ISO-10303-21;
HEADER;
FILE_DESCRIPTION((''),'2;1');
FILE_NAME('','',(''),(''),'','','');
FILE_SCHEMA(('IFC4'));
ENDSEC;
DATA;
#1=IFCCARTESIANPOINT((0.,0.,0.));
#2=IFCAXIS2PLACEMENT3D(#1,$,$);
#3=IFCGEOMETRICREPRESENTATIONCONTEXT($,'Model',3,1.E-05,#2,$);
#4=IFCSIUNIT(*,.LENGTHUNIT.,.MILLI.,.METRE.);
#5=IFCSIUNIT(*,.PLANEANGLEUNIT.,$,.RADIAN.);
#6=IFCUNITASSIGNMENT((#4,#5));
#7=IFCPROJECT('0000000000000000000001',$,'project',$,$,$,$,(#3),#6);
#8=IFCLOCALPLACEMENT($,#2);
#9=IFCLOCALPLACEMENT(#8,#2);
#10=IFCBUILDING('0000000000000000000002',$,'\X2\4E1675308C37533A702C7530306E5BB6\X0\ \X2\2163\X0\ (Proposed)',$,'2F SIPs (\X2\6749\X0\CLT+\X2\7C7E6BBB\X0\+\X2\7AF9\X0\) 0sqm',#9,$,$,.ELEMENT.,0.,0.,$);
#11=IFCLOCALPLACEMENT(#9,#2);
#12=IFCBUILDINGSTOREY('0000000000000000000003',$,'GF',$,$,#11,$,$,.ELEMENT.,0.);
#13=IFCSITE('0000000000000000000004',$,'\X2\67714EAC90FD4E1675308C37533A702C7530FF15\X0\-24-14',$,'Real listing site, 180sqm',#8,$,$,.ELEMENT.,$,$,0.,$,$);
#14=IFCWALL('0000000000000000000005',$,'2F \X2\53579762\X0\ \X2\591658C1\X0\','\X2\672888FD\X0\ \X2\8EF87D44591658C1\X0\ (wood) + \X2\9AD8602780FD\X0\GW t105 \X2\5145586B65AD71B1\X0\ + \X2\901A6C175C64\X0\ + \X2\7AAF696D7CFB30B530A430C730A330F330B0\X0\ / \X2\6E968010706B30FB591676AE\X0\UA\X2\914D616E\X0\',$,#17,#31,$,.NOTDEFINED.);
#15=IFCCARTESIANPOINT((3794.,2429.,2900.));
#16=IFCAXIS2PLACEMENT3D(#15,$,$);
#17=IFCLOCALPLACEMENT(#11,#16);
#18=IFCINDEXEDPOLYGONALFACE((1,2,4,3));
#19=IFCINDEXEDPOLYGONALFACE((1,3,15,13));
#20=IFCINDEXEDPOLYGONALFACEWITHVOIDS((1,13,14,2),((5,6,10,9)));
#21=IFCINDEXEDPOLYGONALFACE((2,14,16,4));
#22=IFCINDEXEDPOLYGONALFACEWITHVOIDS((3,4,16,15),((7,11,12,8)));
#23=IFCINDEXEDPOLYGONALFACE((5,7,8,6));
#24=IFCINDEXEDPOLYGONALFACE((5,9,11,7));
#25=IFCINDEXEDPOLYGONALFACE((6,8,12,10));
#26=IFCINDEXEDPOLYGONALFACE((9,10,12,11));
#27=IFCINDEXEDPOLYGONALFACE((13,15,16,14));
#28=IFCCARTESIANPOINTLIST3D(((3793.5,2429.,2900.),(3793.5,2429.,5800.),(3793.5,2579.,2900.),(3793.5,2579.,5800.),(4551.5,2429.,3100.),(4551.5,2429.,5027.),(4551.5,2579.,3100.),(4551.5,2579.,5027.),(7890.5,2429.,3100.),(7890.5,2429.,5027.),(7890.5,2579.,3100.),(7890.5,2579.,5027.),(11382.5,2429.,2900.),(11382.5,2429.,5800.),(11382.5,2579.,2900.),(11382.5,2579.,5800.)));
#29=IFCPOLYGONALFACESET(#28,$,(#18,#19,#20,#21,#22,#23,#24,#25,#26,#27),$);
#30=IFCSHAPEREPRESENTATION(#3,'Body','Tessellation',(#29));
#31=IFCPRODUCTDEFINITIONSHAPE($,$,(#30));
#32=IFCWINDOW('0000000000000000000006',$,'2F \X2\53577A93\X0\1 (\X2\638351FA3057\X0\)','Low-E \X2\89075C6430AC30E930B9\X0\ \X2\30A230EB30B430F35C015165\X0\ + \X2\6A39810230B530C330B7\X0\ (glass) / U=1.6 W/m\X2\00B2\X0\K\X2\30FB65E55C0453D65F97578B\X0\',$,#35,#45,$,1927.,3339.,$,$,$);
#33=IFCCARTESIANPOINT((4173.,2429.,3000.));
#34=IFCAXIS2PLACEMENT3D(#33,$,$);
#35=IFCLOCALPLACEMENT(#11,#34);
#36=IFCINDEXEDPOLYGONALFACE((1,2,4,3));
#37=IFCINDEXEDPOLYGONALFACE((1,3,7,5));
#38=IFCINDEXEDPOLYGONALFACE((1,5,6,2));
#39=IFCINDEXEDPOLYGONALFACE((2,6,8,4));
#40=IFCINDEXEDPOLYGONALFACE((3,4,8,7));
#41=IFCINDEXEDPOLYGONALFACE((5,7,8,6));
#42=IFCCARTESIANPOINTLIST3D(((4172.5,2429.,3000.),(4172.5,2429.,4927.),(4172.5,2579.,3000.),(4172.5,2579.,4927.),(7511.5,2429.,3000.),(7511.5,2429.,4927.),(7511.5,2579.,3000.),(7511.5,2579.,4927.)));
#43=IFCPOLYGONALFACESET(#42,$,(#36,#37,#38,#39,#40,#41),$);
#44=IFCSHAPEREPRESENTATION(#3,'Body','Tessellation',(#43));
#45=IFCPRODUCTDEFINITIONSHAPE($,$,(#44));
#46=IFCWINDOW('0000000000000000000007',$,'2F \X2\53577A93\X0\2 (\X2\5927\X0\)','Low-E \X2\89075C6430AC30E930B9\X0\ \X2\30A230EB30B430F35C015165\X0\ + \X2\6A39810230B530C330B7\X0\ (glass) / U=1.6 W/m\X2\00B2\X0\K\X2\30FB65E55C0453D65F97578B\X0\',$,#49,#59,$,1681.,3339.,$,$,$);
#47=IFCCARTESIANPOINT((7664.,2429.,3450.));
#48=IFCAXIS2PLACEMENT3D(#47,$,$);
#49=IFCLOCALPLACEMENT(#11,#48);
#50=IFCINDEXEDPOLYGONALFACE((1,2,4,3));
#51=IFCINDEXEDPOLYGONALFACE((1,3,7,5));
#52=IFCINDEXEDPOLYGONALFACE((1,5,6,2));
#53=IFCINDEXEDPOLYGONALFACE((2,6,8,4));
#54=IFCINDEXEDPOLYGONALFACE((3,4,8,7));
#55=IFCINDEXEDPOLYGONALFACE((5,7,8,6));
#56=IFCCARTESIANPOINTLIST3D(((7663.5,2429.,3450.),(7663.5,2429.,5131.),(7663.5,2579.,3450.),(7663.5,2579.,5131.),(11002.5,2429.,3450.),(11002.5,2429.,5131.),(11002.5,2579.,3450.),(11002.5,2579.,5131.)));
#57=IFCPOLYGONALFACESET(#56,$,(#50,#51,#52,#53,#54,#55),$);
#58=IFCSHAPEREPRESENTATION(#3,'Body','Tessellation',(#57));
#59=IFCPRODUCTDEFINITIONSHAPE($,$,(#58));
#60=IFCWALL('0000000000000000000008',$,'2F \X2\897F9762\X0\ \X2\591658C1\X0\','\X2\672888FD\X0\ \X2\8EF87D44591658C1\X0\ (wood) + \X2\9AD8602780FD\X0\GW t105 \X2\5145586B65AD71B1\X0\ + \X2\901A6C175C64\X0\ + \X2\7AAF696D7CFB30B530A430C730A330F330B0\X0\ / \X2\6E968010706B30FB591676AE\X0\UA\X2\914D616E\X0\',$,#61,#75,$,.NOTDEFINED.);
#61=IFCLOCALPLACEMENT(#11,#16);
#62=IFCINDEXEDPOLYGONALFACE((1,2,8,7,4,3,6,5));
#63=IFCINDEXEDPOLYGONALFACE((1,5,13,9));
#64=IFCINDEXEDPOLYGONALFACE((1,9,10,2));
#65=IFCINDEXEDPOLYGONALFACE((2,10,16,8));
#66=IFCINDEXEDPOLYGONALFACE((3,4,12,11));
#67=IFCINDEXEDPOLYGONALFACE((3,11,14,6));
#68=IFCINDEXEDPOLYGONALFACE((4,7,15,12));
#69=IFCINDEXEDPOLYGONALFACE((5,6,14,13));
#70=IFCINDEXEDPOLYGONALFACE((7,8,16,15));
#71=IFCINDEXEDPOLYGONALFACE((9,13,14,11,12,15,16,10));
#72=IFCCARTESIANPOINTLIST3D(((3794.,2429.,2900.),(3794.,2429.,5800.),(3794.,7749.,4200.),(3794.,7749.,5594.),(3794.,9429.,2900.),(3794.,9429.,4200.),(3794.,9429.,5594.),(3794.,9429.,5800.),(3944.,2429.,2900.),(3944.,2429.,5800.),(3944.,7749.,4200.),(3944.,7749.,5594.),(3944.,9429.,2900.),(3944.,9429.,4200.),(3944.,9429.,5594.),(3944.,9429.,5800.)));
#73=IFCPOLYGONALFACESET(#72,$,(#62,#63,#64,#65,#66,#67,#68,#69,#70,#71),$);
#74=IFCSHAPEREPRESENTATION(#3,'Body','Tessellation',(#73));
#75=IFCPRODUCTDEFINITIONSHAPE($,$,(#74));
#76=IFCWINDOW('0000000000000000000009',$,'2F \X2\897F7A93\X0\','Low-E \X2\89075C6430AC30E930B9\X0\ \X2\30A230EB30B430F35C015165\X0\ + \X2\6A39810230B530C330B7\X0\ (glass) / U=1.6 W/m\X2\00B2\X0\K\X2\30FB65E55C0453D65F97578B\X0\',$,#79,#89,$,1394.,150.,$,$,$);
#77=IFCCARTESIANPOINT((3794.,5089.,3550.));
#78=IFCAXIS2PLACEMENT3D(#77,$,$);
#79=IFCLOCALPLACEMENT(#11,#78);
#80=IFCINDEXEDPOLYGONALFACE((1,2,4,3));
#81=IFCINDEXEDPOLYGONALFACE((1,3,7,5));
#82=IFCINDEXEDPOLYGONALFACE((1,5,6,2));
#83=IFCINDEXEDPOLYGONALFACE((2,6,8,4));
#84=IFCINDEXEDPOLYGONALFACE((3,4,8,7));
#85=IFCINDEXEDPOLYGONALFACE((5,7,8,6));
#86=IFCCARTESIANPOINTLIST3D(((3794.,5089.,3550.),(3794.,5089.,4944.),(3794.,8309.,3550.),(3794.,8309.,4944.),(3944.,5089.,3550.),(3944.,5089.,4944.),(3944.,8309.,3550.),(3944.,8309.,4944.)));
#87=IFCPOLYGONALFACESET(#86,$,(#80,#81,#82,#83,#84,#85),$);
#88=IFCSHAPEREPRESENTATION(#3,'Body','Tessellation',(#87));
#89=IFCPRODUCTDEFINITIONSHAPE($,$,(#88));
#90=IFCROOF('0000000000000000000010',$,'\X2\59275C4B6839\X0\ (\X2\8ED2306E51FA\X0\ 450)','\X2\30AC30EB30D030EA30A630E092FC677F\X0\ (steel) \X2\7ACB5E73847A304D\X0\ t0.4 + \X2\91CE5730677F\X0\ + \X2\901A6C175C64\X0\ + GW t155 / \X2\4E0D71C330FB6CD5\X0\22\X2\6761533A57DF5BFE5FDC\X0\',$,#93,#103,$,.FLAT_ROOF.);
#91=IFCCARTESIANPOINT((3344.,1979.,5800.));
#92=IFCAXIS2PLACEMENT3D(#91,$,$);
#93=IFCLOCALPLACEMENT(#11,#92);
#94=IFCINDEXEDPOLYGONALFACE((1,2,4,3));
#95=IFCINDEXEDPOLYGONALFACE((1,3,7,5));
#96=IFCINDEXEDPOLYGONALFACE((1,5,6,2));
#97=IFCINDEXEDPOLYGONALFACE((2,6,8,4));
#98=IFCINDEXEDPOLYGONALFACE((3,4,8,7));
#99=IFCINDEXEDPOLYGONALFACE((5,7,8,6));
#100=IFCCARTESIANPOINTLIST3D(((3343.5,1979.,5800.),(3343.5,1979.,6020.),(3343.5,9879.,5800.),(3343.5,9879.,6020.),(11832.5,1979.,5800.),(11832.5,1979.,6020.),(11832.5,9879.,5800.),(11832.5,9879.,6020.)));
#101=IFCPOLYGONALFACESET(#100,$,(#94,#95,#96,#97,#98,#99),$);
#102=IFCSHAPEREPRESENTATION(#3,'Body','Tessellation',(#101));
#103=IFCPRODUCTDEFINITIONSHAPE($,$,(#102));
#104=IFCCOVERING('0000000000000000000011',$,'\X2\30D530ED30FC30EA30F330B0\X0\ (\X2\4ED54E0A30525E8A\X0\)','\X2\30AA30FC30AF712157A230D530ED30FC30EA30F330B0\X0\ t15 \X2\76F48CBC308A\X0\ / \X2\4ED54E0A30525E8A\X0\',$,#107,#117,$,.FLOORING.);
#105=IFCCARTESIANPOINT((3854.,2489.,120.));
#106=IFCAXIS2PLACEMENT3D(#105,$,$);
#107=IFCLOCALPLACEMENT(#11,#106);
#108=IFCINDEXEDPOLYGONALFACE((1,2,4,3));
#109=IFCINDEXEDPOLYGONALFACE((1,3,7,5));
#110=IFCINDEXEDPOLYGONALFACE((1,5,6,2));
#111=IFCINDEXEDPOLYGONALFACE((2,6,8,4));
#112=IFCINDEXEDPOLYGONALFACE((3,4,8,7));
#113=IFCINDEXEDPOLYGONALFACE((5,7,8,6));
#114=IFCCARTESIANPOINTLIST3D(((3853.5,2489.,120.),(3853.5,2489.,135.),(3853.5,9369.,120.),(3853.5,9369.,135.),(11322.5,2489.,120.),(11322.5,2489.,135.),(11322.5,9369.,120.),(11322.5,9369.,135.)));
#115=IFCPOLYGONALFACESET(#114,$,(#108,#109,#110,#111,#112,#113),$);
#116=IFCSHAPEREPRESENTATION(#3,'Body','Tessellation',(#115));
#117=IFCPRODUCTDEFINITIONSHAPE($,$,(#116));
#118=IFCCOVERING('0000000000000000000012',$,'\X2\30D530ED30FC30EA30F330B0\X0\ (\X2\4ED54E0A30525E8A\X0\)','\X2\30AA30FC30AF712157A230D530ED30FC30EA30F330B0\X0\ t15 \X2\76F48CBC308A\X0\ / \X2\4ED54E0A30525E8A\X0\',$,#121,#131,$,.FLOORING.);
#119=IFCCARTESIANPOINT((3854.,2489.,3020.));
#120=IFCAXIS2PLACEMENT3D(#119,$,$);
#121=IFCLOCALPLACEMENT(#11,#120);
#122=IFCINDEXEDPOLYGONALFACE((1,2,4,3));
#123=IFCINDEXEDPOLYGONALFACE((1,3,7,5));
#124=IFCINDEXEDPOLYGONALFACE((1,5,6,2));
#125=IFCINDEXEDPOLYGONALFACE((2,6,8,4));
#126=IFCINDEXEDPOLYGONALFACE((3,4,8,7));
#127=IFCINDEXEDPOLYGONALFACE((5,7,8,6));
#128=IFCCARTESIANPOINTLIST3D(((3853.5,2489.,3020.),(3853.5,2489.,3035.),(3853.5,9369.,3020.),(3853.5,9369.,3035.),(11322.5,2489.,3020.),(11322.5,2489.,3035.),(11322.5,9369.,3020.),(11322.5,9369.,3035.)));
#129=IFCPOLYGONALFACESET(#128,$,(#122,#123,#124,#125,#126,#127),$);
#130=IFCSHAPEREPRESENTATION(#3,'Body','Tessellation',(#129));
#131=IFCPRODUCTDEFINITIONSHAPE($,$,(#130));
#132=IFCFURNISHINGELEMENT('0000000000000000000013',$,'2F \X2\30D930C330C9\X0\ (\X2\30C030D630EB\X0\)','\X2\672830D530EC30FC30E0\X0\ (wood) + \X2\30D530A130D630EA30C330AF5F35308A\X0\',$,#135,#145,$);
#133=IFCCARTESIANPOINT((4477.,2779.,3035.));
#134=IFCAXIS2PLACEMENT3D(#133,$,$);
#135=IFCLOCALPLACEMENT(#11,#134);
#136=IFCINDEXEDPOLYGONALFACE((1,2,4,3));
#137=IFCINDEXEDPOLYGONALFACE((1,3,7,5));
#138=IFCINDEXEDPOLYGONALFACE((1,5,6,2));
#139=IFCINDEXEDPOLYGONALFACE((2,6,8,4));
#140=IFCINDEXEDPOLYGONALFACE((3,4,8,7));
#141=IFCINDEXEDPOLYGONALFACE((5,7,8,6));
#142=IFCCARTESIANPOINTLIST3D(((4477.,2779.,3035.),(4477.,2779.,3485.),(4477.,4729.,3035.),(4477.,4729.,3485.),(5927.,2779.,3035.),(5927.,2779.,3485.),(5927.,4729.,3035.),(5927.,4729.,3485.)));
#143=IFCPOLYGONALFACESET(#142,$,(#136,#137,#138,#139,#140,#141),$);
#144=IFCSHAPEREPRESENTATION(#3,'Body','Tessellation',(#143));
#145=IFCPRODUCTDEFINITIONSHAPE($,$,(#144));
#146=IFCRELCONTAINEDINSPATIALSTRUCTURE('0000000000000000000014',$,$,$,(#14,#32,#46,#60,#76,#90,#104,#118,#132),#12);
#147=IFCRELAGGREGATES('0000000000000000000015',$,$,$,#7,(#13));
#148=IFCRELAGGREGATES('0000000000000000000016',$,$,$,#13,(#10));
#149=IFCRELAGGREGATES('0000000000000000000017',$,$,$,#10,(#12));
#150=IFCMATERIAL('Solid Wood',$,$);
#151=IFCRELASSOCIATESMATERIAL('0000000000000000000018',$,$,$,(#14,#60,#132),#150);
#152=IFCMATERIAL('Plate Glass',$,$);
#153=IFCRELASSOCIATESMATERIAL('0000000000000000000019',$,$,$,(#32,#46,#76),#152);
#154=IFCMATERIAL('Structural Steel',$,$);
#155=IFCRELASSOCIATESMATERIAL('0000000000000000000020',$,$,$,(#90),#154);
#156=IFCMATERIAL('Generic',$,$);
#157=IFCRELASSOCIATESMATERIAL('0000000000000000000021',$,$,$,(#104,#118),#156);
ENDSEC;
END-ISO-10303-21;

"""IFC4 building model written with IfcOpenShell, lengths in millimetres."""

from ifc_helpers import new_model, si_unit, frame, frame_2d, origin, place, context, project, spatial, rectangle, extrude, material, element, fill, save


model = new_model("IFC4")

# Units and contexts
model_context = context("Model", 3, precision=1e-05, world=origin())
ifc_project = project(units=[si_unit("LENGTHUNIT", "METRE", prefix="MILLI"), si_unit("PLANEANGLEUNIT", "RADIAN")], contexts=[model_context])

# Site, building, storey
site_placement = place(None, origin())
site = spatial("IfcSite", under=ifc_project, at=site_placement, Name="東京都世田谷区瀬田５-24-14", ObjectType="Real listing site, 180sqm", CompositionType="ELEMENT", RefElevation=0.0)
building_placement = place(site_placement, origin())
building = spatial("IfcBuilding", under=site, at=building_placement, Name="世田谷区瀬田の家 Ⅳ (Proposed)", ObjectType="2F SIPs (杉CLT+籾殻+竹) 0sqm", CompositionType="ELEMENT", ElevationOfRefHeight=0.0, ElevationOfTerrain=0.0)
storey_placement = place(building_placement, origin())
storey = spatial("IfcBuildingStorey", under=building, at=storey_placement, Name="GF", CompositionType="ELEMENT", Elevation=0.0)

# Shared definitions
ifc_material_1 = material(Name="Solid Wood")

# Shared definitions
ifc_material_2 = material(Name="Plate Glass")

# Wall, openings, windows
wall_1_placement = place(storey_placement, frame((3794.0, 2429.0, 2900.0)))
wall_1 = element("IfcWall", 1, at=wall_1_placement, inside=storey, material=ifc_material_1, Name="2F 南面 外壁", Description="木製 軸組外壁 (wood) + 高性能GW t105 充填断熱 + 通気層 + 窯業系サイディング / 準耐火・外皮UA配慮", PredefinedType="NOTDEFINED", context=model_context, shape_type="SweptSolid", body=[
    extrude(rectangle(XDim=7589.0, YDim=150.0, at=frame_2d((3794.0, 75.0))), frame((3794.0, 2429.0, 2900.0)), (0.0, 0.0, 1.0), 2900.0),
])
opening_1_placement = place(storey_placement, frame((4173.0, 2429.0, 3000.0)))
opening_1 = element("IfcOpeningElement", 2, at=opening_1_placement, cuts=wall_1, PredefinedType="NOTDEFINED", context=model_context, shape_type="SweptSolid", body=[
    extrude(rectangle(XDim=3339.0, YDim=150.0, at=frame_2d((1669.0, 75.0))), frame((4173.0, 2429.0, 3000.0)), (0.0, 0.0, 1.0), 1927.0),
])
opening_2_placement = place(storey_placement, frame((7664.0, 2429.0, 3450.0)))
opening_2 = element("IfcOpeningElement", 3, at=opening_2_placement, cuts=wall_1, PredefinedType="NOTDEFINED", context=model_context, shape_type="SweptSolid", body=[
    extrude(rectangle(XDim=3339.0, YDim=150.0, at=frame_2d((1669.0, 75.0))), frame((7664.0, 2429.0, 3450.0)), (0.0, 0.0, 1.0), 1681.0),
])
window_1_placement = place(storey_placement, frame((4173.0, 2429.0, 3000.0)))
window_1 = element("IfcWindow", 4, at=window_1_placement, inside=storey, material=ifc_material_2, Name="2F 南窓1 (掃出し)", Description="Low-E 複層ガラス アルゴン封入 + 樹脂サッシ (glass) / U=1.6 W/m²K・日射取得型", OverallHeight=1927.0, OverallWidth=3339.0, context=model_context, shape_type="SweptSolid", body=[
    extrude(rectangle(XDim=3339.0, YDim=150.0, at=frame_2d((1669.0, 75.0))), frame((4173.0, 2429.0, 3000.0)), (0.0, 0.0, 1.0), 1927.0),
])
fill(opening_1, window_1)
window_2_placement = place(storey_placement, frame((7664.0, 2429.0, 3450.0)))
window_2 = element("IfcWindow", 5, at=window_2_placement, inside=storey, material=ifc_material_2, Name="2F 南窓2 (大)", Description="Low-E 複層ガラス アルゴン封入 + 樹脂サッシ (glass) / U=1.6 W/m²K・日射取得型", OverallHeight=1681.0, OverallWidth=3339.0, context=model_context, shape_type="SweptSolid", body=[
    extrude(rectangle(XDim=3339.0, YDim=150.0, at=frame_2d((1669.0, 75.0))), frame((7664.0, 2429.0, 3450.0)), (0.0, 0.0, 1.0), 1681.0),
])
fill(opening_2, window_2)

# Wall, opening, window
wall_2_placement = place(storey_placement, frame((3794.0, 2429.0, 2900.0)))
wall_2 = element("IfcWall", 6, at=wall_2_placement, inside=storey, material=ifc_material_1, Name="2F 西面 外壁", Description="木製 軸組外壁 (wood) + 高性能GW t105 充填断熱 + 通気層 + 窯業系サイディング / 準耐火・外皮UA配慮", PredefinedType="NOTDEFINED", context=model_context, shape_type="SweptSolid", body=[
    extrude(rectangle(XDim=150.0, YDim=7000.0, at=frame_2d((75.0, 3500.0))), frame((3794.0, 2429.0, 2900.0)), (0.0, 0.0, 1.0), 2900.0),
])
opening_3_placement = place(storey_placement, frame((3794.0, 5089.0, 3550.0)))
opening_3 = element("IfcOpeningElement", 7, at=opening_3_placement, cuts=wall_2, PredefinedType="NOTDEFINED", context=model_context, shape_type="SweptSolid", body=[
    extrude(rectangle(XDim=150.0, YDim=3220.0, at=frame_2d((75.0, 1610.0))), frame((3794.0, 5089.0, 3550.0)), (0.0, 0.0, 1.0), 1394.0),
])
window_3_placement = place(storey_placement, frame((3794.0, 5089.0, 3550.0)))
window_3 = element("IfcWindow", 8, at=window_3_placement, inside=storey, material=ifc_material_2, Name="2F 西窓", Description="Low-E 複層ガラス アルゴン封入 + 樹脂サッシ (glass) / U=1.6 W/m²K・日射取得型", OverallHeight=1394.0, OverallWidth=150.0, context=model_context, shape_type="SweptSolid", body=[
    extrude(rectangle(XDim=150.0, YDim=3220.0, at=frame_2d((75.0, 1610.0))), frame((3794.0, 5089.0, 3550.0)), (0.0, 0.0, 1.0), 1394.0),
])
fill(opening_3, window_3)

# Roof
ifc_material_3 = material(Name="Structural Steel")
roof_placement = place(storey_placement, frame((3344.0, 1979.0, 5800.0)))
element("IfcRoof", 9, at=roof_placement, inside=storey, material=ifc_material_3, Name="大屋根 (軒の出 450)", Description="ガルバリウム鋼板 (steel) 立平葺き t0.4 + 野地板 + 通気層 + GW t155 / 不燃・法22条区域対応", PredefinedType="FLAT_ROOF", context=model_context, shape_type="SweptSolid", body=[
    extrude(rectangle(XDim=8489.0, YDim=7900.0, at=frame_2d((4244.0, 3950.0))), frame((3344.0, 1979.0, 5800.0)), (0.0, 0.0, 1.0), 220.0),
])

# Coverings
ifc_material_4 = material(Name="Generic")
covering_1_placement = place(storey_placement, frame((3854.0, 2489.0, 120.0)))
element("IfcCovering", 10, at=covering_1_placement, inside=storey, material=ifc_material_4, Name="フローリング (仕上げ床)", Description="オーク無垢フローリング t15 直貼り / 仕上げ床", PredefinedType="FLOORING", context=model_context, shape_type="SweptSolid", body=[
    extrude(rectangle(XDim=7469.0, YDim=6880.0, at=frame_2d((3734.0, 3440.0))), frame((3854.0, 2489.0, 120.0)), (0.0, 0.0, 1.0), 15.0),
])
covering_2_placement = place(storey_placement, frame((3854.0, 2489.0, 3020.0)))
element("IfcCovering", 11, at=covering_2_placement, inside=storey, material=ifc_material_4, Name="フローリング (仕上げ床)", Description="オーク無垢フローリング t15 直貼り / 仕上げ床", PredefinedType="FLOORING", context=model_context, shape_type="SweptSolid", body=[
    extrude(rectangle(XDim=7469.0, YDim=6880.0, at=frame_2d((3734.0, 3440.0))), frame((3854.0, 2489.0, 3020.0)), (0.0, 0.0, 1.0), 15.0),
])

# Furnishing element
furnishing_placement = place(storey_placement, frame((4477.0, 2779.0, 3035.0)))
element("IfcFurnishingElement", 12, at=furnishing_placement, inside=storey, material=ifc_material_1, Name="2F ベッド (ダブル)", Description="木フレーム (wood) + ファブリック張り", context=model_context, shape_type="SweptSolid", body=[
    extrude(rectangle(XDim=1450.0, YDim=1950.0, at=frame_2d((725.0, 975.0))), frame((4477.0, 2779.0, 3035.0)), (0.0, 0.0, 1.0), 450.0),
])

save(model, "model.ifc")
